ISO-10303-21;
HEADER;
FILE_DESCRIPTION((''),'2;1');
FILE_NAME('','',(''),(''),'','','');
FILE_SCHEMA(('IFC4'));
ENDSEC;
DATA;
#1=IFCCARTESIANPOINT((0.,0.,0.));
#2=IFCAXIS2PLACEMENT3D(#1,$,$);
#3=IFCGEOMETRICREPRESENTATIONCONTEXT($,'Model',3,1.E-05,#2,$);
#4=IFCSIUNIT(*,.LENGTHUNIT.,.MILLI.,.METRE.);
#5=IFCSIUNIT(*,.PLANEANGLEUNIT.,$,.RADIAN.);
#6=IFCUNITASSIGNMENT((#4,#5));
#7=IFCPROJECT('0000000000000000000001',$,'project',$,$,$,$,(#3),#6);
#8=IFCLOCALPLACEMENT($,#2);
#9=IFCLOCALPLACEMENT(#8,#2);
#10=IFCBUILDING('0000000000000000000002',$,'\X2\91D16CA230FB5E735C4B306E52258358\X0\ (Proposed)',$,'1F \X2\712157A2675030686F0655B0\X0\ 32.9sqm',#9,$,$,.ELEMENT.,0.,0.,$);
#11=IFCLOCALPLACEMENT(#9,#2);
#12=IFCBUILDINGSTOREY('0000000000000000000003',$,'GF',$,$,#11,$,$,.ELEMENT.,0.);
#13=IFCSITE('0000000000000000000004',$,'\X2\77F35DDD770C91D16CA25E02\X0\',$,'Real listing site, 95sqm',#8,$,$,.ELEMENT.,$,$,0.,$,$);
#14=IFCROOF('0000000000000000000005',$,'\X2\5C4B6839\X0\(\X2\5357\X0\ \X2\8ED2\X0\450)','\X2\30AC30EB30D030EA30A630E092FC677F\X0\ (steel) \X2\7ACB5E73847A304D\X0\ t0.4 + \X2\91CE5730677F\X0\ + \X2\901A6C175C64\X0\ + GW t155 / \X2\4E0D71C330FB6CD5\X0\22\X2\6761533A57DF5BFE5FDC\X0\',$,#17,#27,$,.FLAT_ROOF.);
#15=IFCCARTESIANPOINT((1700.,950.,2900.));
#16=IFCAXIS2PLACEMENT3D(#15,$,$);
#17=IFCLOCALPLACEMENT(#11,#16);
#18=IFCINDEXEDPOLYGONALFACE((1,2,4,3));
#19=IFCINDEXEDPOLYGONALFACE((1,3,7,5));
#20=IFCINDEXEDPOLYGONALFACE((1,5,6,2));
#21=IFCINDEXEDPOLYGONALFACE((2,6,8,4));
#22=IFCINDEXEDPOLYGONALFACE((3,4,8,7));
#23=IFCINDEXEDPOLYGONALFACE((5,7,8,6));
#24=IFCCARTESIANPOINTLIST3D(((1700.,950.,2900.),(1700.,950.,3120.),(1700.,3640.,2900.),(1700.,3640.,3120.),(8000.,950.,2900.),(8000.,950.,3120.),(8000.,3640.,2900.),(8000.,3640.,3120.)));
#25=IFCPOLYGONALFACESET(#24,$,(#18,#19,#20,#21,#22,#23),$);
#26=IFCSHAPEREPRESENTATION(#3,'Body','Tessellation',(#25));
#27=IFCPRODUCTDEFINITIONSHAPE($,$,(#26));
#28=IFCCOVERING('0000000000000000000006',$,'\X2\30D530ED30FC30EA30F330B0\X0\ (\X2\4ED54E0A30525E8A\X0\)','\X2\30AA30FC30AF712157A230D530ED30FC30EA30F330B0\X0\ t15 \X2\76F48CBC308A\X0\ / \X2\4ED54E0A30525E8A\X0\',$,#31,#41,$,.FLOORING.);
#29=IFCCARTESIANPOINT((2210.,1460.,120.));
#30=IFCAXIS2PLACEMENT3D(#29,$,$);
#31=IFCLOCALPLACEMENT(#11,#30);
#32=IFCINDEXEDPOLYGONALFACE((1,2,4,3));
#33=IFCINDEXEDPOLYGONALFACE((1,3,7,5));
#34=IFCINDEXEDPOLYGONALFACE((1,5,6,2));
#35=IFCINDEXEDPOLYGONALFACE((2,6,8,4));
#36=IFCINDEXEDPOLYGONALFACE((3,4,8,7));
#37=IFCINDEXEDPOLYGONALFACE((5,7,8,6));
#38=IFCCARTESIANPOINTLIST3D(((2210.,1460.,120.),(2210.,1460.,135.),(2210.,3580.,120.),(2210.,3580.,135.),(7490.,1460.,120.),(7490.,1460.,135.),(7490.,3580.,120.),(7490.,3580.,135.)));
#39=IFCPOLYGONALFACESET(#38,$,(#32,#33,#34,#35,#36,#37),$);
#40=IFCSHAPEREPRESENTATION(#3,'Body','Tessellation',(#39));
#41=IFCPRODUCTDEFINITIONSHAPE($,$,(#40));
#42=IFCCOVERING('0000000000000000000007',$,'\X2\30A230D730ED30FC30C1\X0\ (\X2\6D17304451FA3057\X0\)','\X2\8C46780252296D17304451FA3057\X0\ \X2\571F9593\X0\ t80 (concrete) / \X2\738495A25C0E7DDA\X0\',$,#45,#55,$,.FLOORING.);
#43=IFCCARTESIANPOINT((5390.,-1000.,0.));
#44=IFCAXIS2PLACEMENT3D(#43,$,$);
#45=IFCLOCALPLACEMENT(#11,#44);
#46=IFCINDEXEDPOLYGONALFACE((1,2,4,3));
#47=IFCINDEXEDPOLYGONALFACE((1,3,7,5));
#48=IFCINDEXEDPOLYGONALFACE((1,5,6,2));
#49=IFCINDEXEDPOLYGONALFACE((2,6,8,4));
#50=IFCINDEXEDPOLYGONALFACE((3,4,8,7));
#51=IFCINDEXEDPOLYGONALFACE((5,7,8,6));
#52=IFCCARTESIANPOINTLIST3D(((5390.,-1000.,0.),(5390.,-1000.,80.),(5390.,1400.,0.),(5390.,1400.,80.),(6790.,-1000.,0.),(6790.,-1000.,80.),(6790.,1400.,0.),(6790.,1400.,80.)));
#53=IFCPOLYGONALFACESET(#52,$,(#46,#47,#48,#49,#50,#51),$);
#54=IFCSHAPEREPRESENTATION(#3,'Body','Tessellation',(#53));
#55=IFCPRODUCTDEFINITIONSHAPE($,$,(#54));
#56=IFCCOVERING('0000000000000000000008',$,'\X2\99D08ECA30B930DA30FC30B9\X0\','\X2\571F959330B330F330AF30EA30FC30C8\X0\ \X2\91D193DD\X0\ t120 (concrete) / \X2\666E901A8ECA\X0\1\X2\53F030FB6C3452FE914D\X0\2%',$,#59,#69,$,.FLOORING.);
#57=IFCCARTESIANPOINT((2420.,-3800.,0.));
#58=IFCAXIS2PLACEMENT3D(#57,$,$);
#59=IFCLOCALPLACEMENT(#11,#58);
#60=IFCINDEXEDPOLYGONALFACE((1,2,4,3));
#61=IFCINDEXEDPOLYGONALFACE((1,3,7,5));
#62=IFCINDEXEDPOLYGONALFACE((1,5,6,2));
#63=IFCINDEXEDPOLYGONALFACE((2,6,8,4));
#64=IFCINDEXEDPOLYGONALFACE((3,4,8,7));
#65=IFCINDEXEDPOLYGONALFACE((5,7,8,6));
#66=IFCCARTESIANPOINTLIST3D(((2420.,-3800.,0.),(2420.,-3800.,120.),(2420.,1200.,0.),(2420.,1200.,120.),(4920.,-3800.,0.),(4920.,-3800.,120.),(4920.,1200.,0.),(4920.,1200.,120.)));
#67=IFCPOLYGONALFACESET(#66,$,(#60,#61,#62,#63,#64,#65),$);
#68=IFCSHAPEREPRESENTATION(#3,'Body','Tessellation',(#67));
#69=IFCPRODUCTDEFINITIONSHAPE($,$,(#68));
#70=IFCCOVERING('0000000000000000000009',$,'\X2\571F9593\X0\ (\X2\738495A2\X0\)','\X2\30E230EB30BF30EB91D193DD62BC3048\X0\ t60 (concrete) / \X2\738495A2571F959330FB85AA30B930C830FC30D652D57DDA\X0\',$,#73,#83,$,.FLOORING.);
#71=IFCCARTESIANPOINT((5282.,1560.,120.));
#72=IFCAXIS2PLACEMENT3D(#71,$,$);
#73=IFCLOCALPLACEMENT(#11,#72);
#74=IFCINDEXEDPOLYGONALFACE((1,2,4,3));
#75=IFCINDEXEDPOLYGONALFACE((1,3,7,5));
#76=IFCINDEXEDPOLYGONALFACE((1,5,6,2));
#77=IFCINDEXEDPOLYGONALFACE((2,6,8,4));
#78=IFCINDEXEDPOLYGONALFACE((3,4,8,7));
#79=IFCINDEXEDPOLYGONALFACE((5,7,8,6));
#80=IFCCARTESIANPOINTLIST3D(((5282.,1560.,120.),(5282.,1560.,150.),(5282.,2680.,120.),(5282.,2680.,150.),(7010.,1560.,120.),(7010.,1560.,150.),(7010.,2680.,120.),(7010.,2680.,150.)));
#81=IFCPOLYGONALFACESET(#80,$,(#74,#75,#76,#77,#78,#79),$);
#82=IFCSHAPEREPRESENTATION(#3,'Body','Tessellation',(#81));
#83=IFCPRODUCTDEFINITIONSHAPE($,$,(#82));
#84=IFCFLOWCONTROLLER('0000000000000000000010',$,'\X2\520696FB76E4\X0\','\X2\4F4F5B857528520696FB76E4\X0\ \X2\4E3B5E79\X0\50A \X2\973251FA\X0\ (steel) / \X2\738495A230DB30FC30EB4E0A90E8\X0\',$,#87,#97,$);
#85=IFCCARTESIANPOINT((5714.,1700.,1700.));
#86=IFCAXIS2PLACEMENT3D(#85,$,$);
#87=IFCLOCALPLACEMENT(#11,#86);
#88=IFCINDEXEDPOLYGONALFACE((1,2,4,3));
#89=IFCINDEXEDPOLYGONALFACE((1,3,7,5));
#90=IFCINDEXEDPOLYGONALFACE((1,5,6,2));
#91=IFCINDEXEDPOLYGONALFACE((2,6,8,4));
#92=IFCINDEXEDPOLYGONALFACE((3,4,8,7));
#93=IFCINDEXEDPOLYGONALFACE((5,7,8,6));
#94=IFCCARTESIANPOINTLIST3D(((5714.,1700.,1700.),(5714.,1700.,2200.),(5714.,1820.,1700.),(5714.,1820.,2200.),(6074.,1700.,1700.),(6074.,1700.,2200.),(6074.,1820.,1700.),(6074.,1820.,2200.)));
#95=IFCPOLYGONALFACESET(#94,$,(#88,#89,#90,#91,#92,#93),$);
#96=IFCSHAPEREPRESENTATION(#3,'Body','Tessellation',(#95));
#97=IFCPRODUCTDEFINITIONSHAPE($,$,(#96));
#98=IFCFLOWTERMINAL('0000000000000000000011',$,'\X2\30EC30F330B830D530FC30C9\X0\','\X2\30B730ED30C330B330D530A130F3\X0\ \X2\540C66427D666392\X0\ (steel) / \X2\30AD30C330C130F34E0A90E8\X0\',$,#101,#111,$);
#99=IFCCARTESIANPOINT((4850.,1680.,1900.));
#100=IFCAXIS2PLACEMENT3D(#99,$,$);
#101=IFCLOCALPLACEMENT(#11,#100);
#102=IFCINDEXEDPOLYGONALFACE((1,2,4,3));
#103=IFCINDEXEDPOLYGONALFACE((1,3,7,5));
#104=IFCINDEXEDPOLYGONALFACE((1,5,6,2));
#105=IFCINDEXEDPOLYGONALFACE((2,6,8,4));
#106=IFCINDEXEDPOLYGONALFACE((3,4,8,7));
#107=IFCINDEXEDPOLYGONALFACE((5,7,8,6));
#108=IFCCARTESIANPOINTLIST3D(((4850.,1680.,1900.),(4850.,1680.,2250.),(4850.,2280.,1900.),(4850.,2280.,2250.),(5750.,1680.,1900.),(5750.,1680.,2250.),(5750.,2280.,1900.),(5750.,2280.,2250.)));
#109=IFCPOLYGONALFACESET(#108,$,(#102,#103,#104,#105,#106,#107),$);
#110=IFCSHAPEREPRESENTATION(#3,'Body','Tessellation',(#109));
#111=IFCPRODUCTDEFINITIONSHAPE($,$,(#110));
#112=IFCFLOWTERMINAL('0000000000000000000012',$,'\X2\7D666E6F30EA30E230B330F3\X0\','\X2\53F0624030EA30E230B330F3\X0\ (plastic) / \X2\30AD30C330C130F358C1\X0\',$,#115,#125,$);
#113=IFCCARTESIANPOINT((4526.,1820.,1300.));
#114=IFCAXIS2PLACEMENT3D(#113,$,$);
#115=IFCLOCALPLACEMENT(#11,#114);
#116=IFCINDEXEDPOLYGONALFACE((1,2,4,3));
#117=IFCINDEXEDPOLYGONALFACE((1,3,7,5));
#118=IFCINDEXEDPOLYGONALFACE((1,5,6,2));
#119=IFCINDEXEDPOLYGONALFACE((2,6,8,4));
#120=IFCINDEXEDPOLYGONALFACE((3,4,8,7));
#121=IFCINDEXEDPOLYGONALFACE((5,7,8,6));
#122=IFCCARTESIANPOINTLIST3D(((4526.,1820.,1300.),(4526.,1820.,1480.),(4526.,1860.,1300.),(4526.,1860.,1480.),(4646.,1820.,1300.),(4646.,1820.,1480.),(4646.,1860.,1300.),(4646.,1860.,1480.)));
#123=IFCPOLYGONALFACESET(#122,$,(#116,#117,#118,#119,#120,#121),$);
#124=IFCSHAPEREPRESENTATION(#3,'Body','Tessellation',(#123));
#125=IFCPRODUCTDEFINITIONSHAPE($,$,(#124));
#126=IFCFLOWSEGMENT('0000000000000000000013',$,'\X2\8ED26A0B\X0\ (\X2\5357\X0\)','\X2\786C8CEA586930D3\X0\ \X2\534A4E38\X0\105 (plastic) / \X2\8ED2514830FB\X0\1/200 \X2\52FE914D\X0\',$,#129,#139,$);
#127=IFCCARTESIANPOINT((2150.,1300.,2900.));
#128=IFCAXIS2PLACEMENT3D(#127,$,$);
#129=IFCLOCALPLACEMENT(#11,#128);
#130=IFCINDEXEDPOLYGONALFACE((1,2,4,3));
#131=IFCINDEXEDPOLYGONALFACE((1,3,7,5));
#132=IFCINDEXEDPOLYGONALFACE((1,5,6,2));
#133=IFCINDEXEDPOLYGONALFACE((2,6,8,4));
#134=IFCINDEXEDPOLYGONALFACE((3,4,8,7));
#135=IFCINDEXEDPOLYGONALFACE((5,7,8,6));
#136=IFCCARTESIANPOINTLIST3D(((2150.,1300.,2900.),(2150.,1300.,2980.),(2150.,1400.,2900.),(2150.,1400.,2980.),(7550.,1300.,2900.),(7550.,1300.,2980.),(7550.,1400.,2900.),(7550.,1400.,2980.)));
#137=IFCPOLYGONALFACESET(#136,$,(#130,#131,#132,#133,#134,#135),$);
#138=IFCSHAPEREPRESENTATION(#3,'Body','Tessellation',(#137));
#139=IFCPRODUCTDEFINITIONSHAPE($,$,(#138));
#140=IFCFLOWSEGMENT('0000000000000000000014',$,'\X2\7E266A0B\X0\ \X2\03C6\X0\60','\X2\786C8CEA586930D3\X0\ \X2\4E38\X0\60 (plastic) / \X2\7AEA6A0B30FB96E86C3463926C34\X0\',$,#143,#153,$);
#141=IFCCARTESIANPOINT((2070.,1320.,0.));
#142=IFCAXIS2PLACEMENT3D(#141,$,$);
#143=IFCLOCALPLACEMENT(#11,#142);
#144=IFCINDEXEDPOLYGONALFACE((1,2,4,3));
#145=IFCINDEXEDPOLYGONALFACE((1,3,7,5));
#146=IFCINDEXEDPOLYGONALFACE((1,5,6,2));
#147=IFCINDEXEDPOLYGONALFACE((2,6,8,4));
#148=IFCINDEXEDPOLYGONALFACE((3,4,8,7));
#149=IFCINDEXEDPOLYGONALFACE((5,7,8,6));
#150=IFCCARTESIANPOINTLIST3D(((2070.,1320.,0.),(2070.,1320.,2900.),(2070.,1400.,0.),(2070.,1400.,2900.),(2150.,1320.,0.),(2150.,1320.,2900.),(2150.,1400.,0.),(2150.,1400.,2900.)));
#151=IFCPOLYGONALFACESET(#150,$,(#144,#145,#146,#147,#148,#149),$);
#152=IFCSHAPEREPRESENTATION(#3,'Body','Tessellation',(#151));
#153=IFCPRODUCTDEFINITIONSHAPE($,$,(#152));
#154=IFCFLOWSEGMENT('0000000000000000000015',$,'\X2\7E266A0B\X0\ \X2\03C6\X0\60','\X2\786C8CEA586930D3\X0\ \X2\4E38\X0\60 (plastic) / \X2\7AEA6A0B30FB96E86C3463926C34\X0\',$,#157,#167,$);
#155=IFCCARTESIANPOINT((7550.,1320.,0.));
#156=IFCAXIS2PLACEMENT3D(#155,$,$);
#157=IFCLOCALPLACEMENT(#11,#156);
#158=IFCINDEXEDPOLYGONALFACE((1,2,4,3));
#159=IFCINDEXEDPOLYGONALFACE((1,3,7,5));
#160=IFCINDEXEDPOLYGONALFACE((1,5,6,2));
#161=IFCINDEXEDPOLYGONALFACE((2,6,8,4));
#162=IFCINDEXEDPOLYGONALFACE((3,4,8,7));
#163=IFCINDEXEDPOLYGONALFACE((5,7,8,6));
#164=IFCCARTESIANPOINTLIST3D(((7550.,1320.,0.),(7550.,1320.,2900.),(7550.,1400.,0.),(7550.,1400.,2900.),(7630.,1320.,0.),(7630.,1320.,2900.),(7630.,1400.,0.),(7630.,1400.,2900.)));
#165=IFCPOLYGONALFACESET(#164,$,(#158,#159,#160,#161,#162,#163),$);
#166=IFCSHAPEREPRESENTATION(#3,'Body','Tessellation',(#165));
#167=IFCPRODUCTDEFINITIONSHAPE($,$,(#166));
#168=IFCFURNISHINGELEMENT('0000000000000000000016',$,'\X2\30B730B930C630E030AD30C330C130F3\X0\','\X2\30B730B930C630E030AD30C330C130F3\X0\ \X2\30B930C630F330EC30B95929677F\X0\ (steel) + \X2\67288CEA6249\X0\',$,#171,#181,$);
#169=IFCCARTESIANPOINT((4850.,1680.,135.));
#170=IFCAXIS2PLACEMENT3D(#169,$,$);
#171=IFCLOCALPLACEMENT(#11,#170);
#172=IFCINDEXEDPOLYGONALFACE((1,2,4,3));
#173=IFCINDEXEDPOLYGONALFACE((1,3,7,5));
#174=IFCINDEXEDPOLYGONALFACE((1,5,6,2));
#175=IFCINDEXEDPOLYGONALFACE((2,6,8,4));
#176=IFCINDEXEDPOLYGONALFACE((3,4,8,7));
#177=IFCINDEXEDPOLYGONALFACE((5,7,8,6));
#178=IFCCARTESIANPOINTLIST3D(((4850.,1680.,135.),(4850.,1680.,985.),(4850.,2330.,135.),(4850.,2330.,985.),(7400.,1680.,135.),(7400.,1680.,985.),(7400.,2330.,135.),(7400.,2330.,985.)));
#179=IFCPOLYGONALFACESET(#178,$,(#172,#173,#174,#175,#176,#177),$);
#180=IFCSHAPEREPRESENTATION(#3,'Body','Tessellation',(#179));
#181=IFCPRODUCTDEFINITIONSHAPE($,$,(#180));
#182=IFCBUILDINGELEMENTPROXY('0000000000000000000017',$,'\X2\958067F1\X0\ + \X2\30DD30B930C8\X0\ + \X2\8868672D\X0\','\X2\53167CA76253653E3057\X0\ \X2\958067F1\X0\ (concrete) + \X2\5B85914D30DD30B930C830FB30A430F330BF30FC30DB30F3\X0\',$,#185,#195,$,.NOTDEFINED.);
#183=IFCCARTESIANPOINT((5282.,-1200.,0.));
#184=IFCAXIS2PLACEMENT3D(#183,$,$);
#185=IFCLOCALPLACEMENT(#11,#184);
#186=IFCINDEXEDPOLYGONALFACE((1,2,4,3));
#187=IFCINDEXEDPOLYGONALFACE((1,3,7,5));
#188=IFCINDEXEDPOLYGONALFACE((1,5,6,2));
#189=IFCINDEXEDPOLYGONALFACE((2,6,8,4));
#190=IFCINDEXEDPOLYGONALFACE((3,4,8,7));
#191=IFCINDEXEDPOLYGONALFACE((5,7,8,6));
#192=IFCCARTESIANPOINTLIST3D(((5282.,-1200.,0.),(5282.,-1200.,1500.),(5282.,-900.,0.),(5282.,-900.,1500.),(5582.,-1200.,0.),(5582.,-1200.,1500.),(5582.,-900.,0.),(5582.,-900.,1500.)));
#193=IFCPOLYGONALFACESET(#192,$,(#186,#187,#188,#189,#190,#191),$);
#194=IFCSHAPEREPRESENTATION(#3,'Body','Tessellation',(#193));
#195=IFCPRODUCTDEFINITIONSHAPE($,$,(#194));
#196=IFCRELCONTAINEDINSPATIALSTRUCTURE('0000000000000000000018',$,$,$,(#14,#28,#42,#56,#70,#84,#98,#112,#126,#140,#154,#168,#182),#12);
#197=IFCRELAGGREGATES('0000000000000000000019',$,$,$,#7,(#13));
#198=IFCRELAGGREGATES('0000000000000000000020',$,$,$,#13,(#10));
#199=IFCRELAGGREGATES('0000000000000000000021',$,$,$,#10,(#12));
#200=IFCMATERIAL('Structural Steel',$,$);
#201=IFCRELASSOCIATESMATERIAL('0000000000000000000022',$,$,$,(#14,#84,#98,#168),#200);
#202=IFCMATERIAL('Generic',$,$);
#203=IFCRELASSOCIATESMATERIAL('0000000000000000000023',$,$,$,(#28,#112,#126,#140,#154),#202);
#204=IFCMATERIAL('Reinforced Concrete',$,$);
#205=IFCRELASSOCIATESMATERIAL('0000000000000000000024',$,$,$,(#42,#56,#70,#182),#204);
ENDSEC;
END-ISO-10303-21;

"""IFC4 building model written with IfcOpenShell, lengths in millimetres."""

from ifc_helpers import new_model, si_unit, frame, frame_2d, origin, place, context, project, spatial, rectangle, extrude, material, element, save


model = new_model("IFC4")

# Units and contexts
model_context = context("Model", 3, precision=1e-05, world=origin())
ifc_project = project(units=[si_unit("LENGTHUNIT", "METRE", prefix="MILLI"), si_unit("PLANEANGLEUNIT", "RADIAN")], contexts=[model_context])

# Site, building, storey
site_placement = place(None, origin())
site = spatial("IfcSite", under=ifc_project, at=site_placement, Name="石川県金沢市", ObjectType="Real listing site, 95sqm", CompositionType="ELEMENT", RefElevation=0.0)
building_placement = place(site_placement, origin())
building = spatial("IfcBuilding", under=site, at=building_placement, Name="金沢・平屋の別荘 (Proposed)", ObjectType="1F 無垢材と漆喰 32.9sqm", CompositionType="ELEMENT", ElevationOfRefHeight=0.0, ElevationOfTerrain=0.0)
storey_placement = place(building_placement, origin())
storey = spatial("IfcBuildingStorey", under=building, at=storey_placement, Name="GF", CompositionType="ELEMENT", Elevation=0.0)

# Shared definitions
ifc_material_1 = material(Name="Reinforced Concrete")

# Roof
ifc_material_2 = material(Name="Structural Steel")
roof_placement = place(storey_placement, frame((1700.0, 950.0, 2900.0)))
element("IfcRoof", 1, at=roof_placement, inside=storey, material=ifc_material_2, Name="屋根(南 軒450)", Description="ガルバリウム鋼板 (steel) 立平葺き t0.4 + 野地板 + 通気層 + GW t155 / 不燃・法22条区域対応", PredefinedType="FLAT_ROOF", context=model_context, shape_type="SweptSolid", body=[
    extrude(rectangle(XDim=6300.0, YDim=2690.0, at=frame_2d((3150.0, 1345.0))), frame((1700.0, 950.0, 2900.0)), (0.0, 0.0, 1.0), 220.0),
])

# Coverings
ifc_material_3 = material(Name="Generic")
covering_1_placement = place(storey_placement, frame((2210.0, 1460.0, 120.0)))
element("IfcCovering", 2, at=covering_1_placement, inside=storey, material=ifc_material_3, Name="フローリング (仕上げ床)", Description="オーク無垢フローリング t15 直貼り / 仕上げ床", PredefinedType="FLOORING", context=model_context, shape_type="SweptSolid", body=[
    extrude(rectangle(XDim=5280.0, YDim=2120.0, at=frame_2d((2640.0, 1060.0))), frame((2210.0, 1460.0, 120.0)), (0.0, 0.0, 1.0), 15.0),
])
covering_2_placement = place(storey_placement, frame((5390.0, -1000.0, 0.0)))
element("IfcCovering", 3, at=covering_2_placement, inside=storey, material=ifc_material_1, Name="アプローチ (洗い出し)", Description="豆砂利洗い出し 土間 t80 (concrete) / 玄関導線", PredefinedType="FLOORING", context=model_context, shape_type="SweptSolid", body=[
    extrude(rectangle(XDim=1400.0, YDim=2400.0, at=frame_2d((700.0, 1200.0))), frame((5390.0, -1000.0, 0.0)), (0.0, 0.0, 1.0), 80.0),
])
covering_3_placement = place(storey_placement, frame((2420.0, -3800.0, 0.0)))
element("IfcCovering", 4, at=covering_3_placement, inside=storey, material=ifc_material_1, Name="駐車スペース", Description="土間コンクリート 金鏝 t120 (concrete) / 普通車1台・水勾配2%", PredefinedType="FLOORING", context=model_context, shape_type="SweptSolid", body=[
    extrude(rectangle(XDim=2500.0, YDim=5000.0, at=frame_2d((1250.0, 2500.0))), frame((2420.0, -3800.0, 0.0)), (0.0, 0.0, 1.0), 120.0),
])
covering_4_placement = place(storey_placement, frame((5282.0, 1560.0, 120.0)))
element("IfcCovering", 5, at=covering_4_placement, inside=storey, material=ifc_material_1, Name="土間 (玄関)", Description="モルタル金鏝押え t60 (concrete) / 玄関土間・薪ストーブ動線", PredefinedType="FLOORING", context=model_context, shape_type="SweptSolid", body=[
    extrude(rectangle(XDim=1728.0, YDim=1120.0, at=frame_2d((864.0, 560.0))), frame((5282.0, 1560.0, 120.0)), (0.0, 0.0, 1.0), 30.0),
])

# Flow controller
flow_controller_placement = place(storey_placement, frame((5714.0, 1700.0, 1700.0)))
element("IfcFlowController", 6, at=flow_controller_placement, inside=storey, material=ifc_material_2, Name="分電盤", Description="住宅用分電盤 主幹50A 露出 (steel) / 玄関ホール上部", context=model_context, shape_type="SweptSolid", body=[
    extrude(rectangle(XDim=360.0, YDim=120.0, at=frame_2d((180.0, 60.0))), frame((5714.0, 1700.0, 1700.0)), (0.0, 0.0, 1.0), 500.0),
])

# Flow terminals
flow_terminal_1_placement = place(storey_placement, frame((4850.0, 1680.0, 1900.0)))
element("IfcFlowTerminal", 7, at=flow_terminal_1_placement, inside=storey, material=ifc_material_2, Name="レンジフード", Description="シロッコファン 同時給排 (steel) / キッチン上部", context=model_context, shape_type="SweptSolid", body=[
    extrude(rectangle(XDim=900.0, YDim=600.0, at=frame_2d((450.0, 300.0))), frame((4850.0, 1680.0, 1900.0)), (0.0, 0.0, 1.0), 350.0),
])
flow_terminal_2_placement = place(storey_placement, frame((4526.0, 1820.0, 1300.0)))
element("IfcFlowTerminal", 8, at=flow_terminal_2_placement, inside=storey, material=ifc_material_3, Name="給湯リモコン", Description="台所リモコン (plastic) / キッチン壁", context=model_context, shape_type="SweptSolid", body=[
    extrude(rectangle(XDim=120.0, YDim=40.0, at=frame_2d((60.0, 20.0))), frame((4526.0, 1820.0, 1300.0)), (0.0, 0.0, 1.0), 180.0),
])

# Flow segments
flow_segment_1_placement = place(storey_placement, frame((2150.0, 1300.0, 2900.0)))
element("IfcFlowSegment", 9, at=flow_segment_1_placement, inside=storey, material=ifc_material_3, Name="軒樋 (南)", Description="硬質塩ビ 半丸105 (plastic) / 軒先・1/200 勾配", context=model_context, shape_type="SweptSolid", body=[
    extrude(rectangle(XDim=5400.0, YDim=100.0, at=frame_2d((2700.0, 50.0))), frame((2150.0, 1300.0, 2900.0)), (0.0, 0.0, 1.0), 80.0),
])
flow_segment_2_placement = place(storey_placement, frame((2070.0, 1320.0, 0.0)))
element("IfcFlowSegment", 10, at=flow_segment_2_placement, inside=storey, material=ifc_material_3, Name="縦樋 φ60", Description="硬質塩ビ 丸60 (plastic) / 竪樋・雨水排水", context=model_context, shape_type="SweptSolid", body=[
    extrude(rectangle(XDim=80.0, YDim=80.0, at=frame_2d((40.0, 40.0))), frame((2070.0, 1320.0, 0.0)), (0.0, 0.0, 1.0), 2900.0),
])
flow_segment_3_placement = place(storey_placement, frame((7550.0, 1320.0, 0.0)))
element("IfcFlowSegment", 11, at=flow_segment_3_placement, inside=storey, material=ifc_material_3, Name="縦樋 φ60", Description="硬質塩ビ 丸60 (plastic) / 竪樋・雨水排水", context=model_context, shape_type="SweptSolid", body=[
    extrude(rectangle(XDim=80.0, YDim=80.0, at=frame_2d((40.0, 40.0))), frame((7550.0, 1320.0, 0.0)), (0.0, 0.0, 1.0), 2900.0),
])

# Furnishing element
furnishing_placement = place(storey_placement, frame((4850.0, 1680.0, 135.0)))
element("IfcFurnishingElement", 12, at=furnishing_placement, inside=storey, material=ifc_material_2, Name="システムキッチン", Description="システムキッチン ステンレス天板 (steel) + 木質扉", context=model_context, shape_type="SweptSolid", body=[
    extrude(rectangle(XDim=2550.0, YDim=650.0, at=frame_2d((1275.0, 325.0))), frame((4850.0, 1680.0, 135.0)), (0.0, 0.0, 1.0), 850.0),
])

# Building element proxy
proxy_placement = place(storey_placement, frame((5282.0, -1200.0, 0.0)))
element("IfcBuildingElementProxy", 13, at=proxy_placement, inside=storey, material=ifc_material_1, Name="門柱 + ポスト + 表札", Description="化粧打放し 門柱 (concrete) + 宅配ポスト・インターホン", PredefinedType="NOTDEFINED", context=model_context, shape_type="SweptSolid", body=[
    extrude(rectangle(XDim=300.0, YDim=300.0, at=frame_2d((150.0, 150.0))), frame((5282.0, -1200.0, 0.0)), (0.0, 0.0, 1.0), 1500.0),
])

save(model, "model.ifc")
